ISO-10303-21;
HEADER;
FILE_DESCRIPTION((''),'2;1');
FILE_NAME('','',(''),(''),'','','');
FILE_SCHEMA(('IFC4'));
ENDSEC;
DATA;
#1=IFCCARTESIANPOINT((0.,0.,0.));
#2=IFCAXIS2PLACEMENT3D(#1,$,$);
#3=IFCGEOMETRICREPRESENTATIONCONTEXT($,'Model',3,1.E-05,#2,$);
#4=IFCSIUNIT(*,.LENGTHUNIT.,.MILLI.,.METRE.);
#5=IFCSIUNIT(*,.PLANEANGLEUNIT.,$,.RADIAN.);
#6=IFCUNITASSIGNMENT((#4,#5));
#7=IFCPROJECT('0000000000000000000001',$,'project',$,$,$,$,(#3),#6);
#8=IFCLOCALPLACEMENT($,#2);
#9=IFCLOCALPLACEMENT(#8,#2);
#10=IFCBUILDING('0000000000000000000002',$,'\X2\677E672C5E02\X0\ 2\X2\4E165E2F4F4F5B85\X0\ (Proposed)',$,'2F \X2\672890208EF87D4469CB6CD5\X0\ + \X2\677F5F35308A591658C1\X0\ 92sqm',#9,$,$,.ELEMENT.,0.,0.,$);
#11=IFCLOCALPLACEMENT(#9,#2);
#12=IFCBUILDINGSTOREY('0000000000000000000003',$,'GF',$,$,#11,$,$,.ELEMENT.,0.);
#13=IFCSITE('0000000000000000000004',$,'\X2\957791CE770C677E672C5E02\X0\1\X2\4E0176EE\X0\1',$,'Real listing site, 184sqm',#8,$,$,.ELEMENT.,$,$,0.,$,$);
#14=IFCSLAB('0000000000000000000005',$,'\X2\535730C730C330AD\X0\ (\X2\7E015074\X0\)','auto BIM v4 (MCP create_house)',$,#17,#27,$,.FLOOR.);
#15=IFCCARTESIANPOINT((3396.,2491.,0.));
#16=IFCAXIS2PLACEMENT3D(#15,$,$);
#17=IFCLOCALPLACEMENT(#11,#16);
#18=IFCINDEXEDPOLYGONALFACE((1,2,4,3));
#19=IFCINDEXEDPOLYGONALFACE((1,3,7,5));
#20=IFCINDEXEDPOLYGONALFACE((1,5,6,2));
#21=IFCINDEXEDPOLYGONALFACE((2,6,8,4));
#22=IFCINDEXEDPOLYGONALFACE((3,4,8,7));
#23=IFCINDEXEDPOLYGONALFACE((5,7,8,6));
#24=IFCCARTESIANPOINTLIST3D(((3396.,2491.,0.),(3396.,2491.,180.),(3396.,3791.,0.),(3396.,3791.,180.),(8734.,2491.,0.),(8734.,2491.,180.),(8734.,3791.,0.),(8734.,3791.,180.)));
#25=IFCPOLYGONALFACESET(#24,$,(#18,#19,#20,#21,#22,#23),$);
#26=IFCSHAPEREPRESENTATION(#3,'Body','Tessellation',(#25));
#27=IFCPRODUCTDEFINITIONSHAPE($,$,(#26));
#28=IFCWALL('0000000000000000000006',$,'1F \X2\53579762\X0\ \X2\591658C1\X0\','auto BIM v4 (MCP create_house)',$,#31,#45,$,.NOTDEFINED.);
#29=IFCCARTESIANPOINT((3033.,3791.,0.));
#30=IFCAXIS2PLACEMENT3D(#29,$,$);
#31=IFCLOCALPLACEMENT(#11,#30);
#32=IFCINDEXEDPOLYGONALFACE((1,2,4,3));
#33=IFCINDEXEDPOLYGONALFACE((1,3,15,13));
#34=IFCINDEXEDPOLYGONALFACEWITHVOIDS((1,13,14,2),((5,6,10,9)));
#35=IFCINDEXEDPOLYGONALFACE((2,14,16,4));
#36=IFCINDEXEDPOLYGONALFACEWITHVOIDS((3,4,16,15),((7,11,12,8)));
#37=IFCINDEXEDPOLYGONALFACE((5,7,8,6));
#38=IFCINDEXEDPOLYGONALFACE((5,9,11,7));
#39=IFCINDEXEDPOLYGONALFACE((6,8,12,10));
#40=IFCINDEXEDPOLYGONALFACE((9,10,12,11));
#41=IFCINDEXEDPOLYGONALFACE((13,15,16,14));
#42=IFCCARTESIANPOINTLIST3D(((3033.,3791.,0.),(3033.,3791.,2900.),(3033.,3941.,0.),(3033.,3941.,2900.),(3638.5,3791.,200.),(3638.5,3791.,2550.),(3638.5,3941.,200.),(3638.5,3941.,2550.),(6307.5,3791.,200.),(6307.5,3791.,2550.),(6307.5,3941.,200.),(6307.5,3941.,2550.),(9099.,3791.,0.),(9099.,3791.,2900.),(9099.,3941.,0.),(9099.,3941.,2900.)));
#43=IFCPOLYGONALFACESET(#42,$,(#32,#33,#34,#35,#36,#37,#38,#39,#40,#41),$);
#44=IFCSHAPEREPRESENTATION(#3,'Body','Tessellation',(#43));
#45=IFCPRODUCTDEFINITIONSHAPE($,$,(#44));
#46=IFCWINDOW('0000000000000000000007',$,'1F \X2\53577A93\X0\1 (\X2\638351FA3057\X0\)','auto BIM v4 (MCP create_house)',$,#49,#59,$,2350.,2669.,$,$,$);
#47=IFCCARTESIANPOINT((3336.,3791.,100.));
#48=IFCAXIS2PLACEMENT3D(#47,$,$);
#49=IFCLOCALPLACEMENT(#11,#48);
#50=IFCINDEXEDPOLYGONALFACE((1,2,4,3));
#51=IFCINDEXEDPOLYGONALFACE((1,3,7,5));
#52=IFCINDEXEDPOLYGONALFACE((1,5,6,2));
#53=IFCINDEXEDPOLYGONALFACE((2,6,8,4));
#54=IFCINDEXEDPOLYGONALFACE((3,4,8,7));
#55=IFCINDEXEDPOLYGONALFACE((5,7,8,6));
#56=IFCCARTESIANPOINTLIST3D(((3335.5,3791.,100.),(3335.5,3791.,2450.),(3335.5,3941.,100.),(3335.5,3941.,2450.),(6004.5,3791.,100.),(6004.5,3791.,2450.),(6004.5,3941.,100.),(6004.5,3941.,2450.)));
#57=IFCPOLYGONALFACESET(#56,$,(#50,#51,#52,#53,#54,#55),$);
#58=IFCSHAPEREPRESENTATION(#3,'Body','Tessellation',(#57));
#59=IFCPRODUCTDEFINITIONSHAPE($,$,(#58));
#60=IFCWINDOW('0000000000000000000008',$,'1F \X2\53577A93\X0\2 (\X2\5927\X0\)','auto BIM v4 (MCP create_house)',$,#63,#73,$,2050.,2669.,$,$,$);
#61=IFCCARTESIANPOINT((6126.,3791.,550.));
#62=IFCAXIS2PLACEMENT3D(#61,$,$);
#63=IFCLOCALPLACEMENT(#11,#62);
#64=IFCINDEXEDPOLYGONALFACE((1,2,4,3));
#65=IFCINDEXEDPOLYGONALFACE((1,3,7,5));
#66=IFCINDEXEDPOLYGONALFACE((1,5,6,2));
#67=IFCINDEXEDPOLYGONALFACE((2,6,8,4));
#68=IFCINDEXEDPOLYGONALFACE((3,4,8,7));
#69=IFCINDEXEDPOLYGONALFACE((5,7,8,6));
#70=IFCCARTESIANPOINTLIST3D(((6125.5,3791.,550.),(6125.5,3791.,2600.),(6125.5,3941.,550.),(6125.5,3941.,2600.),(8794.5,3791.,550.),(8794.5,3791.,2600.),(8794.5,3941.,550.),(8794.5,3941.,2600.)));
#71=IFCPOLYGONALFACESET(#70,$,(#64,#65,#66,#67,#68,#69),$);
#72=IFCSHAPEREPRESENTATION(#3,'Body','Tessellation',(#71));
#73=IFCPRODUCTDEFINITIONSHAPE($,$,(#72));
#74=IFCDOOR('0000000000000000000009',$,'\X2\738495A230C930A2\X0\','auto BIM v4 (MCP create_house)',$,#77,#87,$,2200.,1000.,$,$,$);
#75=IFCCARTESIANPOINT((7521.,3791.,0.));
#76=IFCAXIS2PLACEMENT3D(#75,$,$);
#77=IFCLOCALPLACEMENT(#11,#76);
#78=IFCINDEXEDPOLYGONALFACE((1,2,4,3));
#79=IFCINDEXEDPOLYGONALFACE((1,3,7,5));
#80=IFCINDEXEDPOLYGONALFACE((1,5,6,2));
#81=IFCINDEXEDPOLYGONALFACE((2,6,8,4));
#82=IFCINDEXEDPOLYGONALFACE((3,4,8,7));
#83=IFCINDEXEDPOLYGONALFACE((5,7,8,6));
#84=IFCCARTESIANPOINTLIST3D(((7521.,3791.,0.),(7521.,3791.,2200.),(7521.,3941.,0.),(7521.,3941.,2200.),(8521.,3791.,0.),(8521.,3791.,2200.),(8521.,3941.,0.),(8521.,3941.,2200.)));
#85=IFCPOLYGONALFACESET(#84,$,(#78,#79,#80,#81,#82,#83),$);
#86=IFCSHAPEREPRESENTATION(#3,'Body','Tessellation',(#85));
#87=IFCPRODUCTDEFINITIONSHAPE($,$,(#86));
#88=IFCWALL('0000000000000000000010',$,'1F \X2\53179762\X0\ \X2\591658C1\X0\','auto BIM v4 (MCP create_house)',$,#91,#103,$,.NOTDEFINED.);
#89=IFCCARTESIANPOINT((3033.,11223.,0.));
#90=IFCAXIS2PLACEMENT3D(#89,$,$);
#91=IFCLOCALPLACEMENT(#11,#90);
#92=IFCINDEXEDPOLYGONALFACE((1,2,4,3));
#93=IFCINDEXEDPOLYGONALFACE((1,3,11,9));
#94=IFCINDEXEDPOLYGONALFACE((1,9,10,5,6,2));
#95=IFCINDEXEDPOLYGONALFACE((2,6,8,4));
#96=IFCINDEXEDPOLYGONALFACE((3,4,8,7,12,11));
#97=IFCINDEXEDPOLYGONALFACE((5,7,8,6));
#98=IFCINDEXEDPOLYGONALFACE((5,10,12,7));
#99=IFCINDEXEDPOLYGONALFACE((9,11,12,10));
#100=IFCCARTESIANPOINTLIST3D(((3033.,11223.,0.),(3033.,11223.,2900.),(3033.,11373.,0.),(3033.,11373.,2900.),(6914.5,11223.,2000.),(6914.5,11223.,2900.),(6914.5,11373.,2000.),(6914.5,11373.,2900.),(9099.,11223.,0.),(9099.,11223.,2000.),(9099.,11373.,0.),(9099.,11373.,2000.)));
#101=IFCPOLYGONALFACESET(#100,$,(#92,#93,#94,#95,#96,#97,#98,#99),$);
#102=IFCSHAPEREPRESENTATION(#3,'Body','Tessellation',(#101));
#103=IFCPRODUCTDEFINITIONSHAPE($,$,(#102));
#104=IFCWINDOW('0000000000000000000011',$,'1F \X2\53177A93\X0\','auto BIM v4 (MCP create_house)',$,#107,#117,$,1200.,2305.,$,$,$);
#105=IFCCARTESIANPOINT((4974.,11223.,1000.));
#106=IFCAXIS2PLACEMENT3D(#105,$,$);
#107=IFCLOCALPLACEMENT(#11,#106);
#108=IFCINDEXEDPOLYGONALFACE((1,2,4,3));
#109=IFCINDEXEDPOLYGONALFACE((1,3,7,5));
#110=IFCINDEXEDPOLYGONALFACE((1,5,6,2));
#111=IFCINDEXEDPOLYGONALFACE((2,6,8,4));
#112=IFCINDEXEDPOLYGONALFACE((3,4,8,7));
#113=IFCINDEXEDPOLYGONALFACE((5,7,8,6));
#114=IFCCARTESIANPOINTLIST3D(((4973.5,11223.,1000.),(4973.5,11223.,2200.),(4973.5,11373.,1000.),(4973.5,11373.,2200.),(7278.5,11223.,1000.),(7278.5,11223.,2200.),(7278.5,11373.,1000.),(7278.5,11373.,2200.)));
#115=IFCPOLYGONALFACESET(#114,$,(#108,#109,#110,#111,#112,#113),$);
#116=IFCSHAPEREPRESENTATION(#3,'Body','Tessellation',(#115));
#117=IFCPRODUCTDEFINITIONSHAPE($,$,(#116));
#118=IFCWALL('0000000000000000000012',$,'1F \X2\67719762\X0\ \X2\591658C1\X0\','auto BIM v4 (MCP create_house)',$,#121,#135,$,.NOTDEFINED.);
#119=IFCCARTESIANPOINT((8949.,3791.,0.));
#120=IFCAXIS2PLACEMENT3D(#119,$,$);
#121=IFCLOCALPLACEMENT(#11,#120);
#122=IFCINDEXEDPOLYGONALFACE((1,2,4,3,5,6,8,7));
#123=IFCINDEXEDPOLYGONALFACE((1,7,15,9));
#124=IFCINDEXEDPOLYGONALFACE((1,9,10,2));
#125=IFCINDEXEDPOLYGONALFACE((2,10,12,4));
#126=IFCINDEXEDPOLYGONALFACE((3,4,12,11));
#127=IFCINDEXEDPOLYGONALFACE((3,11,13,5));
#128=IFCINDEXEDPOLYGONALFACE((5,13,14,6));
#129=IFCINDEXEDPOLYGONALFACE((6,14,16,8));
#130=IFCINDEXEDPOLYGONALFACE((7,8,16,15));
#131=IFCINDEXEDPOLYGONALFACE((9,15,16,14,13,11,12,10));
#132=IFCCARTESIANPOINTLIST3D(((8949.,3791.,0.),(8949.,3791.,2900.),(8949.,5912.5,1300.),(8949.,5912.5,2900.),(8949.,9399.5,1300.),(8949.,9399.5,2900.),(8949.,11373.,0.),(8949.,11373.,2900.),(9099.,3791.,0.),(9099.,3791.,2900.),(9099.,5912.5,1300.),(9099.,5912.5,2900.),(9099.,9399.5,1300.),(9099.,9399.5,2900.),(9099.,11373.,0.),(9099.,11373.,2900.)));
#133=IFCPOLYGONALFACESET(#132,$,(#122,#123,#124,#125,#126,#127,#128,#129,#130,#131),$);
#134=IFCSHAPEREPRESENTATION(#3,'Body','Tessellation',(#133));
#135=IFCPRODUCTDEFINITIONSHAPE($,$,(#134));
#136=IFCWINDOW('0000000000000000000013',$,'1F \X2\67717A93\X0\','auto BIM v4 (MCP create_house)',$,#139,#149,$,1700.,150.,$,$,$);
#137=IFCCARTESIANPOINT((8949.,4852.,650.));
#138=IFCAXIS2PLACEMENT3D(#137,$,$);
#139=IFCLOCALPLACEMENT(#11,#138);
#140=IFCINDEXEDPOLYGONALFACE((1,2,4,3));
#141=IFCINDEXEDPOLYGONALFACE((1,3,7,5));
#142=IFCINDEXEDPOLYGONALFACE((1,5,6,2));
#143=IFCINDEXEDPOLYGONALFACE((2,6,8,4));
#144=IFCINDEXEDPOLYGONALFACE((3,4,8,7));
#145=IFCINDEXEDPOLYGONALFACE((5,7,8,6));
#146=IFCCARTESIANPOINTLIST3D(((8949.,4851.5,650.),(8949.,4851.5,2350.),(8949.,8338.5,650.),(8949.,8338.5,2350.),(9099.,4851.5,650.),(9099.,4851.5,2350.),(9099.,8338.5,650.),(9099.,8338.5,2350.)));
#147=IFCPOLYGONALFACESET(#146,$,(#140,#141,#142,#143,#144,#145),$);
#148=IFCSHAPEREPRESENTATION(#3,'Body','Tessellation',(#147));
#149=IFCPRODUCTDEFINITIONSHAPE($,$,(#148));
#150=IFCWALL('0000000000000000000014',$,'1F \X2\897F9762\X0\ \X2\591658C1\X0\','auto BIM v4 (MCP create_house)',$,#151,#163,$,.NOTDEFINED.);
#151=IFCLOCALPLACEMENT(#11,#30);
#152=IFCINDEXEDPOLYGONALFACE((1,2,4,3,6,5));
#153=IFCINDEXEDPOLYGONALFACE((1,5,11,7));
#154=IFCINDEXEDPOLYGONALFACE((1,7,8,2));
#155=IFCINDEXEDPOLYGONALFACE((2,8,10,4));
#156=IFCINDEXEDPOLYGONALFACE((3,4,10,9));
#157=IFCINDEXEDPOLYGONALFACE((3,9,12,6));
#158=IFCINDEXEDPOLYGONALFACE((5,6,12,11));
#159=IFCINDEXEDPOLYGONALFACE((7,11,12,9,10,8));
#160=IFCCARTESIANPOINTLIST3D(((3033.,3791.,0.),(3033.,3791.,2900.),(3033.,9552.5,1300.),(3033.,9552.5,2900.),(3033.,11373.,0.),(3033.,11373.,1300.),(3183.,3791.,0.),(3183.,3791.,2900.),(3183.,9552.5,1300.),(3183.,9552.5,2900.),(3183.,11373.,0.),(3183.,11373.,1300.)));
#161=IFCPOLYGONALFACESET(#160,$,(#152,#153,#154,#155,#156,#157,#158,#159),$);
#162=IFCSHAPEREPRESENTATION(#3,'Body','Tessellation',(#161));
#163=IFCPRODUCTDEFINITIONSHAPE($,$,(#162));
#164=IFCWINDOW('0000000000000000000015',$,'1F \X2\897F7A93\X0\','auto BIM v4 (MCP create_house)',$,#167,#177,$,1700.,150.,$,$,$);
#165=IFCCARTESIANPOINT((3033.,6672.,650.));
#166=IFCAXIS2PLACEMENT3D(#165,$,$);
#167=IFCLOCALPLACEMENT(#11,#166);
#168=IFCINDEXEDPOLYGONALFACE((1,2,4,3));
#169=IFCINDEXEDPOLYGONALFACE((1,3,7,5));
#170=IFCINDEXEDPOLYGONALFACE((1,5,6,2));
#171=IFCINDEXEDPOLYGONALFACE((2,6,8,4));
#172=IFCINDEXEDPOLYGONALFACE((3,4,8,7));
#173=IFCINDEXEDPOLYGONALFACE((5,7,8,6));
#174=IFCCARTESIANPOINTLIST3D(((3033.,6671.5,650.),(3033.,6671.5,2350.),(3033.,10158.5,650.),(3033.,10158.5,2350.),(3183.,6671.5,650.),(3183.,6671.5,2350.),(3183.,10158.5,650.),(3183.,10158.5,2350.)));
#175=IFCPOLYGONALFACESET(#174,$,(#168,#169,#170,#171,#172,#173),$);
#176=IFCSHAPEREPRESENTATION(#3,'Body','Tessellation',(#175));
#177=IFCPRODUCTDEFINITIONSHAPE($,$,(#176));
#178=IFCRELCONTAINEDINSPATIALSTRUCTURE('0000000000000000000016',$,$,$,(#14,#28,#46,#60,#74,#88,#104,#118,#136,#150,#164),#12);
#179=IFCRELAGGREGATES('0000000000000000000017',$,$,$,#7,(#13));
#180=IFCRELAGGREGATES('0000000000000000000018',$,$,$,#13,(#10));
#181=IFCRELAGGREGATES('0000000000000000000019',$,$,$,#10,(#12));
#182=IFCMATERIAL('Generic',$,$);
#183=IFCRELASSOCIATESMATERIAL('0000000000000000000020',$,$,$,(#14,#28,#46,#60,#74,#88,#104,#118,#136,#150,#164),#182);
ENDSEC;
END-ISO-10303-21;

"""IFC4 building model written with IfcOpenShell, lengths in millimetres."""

from ifc_helpers import new_model, si_unit, frame, frame_2d, origin, place, context, project, spatial, rectangle, extrude, material, element, fill, save


model = new_model("IFC4")

# Units and contexts
model_context = context("Model", 3, precision=1e-05, world=origin())
ifc_project = project(units=[si_unit("LENGTHUNIT", "METRE", prefix="MILLI"), si_unit("PLANEANGLEUNIT", "RADIAN")], contexts=[model_context])

# Site, building, storey
site_placement = place(None, origin())
site = spatial("IfcSite", under=ifc_project, at=site_placement, Name="長野県松本市1丁目1", ObjectType="Real listing site, 184sqm", CompositionType="ELEMENT", RefElevation=0.0)
building_placement = place(site_placement, origin())
building = spatial("IfcBuilding", under=site, at=building_placement, Name="松本市 2世帯住宅 (Proposed)", ObjectType="2F 木造軸組構法 + 板張り外壁 92sqm", CompositionType="ELEMENT", ElevationOfRefHeight=0.0, ElevationOfTerrain=0.0)
storey_placement = place(building_placement, origin())
storey = spatial("IfcBuildingStorey", under=building, at=storey_placement, Name="GF", CompositionType="ELEMENT", Elevation=0.0)

# Slab
ifc_material = material(Name="Generic")
slab_1_placement = place(storey_placement, frame((3396.0, 2491.0, 0.0)))
element("IfcSlab", 1, at=slab_1_placement, inside=storey, material=ifc_material, Name="南デッキ (縁側)", Description="auto BIM v4 (MCP create_house)", PredefinedType="FLOOR", context=model_context, shape_type="SweptSolid", body=[
    extrude(rectangle(XDim=5338.0, YDim=1300.0, at=frame_2d((2669.0, 650.0))), frame((3396.0, 2491.0, 0.0)), (0.0, 0.0, 1.0), 180.0),
])

# Wall, openings, windows, door
wall_1_placement = place(storey_placement, frame((3033.0, 3791.0, 0.0)))
wall_1 = element("IfcWall", 2, at=wall_1_placement, inside=storey, material=ifc_material, Name="1F 南面 外壁", Description="auto BIM v4 (MCP create_house)", PredefinedType="NOTDEFINED", context=model_context, shape_type="SweptSolid", body=[
    extrude(rectangle(XDim=6066.0, YDim=150.0, at=frame_2d((3033.0, 75.0))), frame((3033.0, 3791.0, 0.0)), (0.0, 0.0, 1.0), 2900.0),
])
opening_1_placement = place(storey_placement, frame((3336.0, 3791.0, 100.0)))
opening_1 = element("IfcOpeningElement", 3, at=opening_1_placement, cuts=wall_1, PredefinedType="NOTDEFINED", context=model_context, shape_type="SweptSolid", body=[
    extrude(rectangle(XDim=2669.0, YDim=150.0, at=frame_2d((1334.0, 75.0))), frame((3336.0, 3791.0, 100.0)), (0.0, 0.0, 1.0), 2350.0),
])
opening_2_placement = place(storey_placement, frame((6126.0, 3791.0, 550.0)))
opening_2 = element("IfcOpeningElement", 4, at=opening_2_placement, cuts=wall_1, PredefinedType="NOTDEFINED", context=model_context, shape_type="SweptSolid", body=[
    extrude(rectangle(XDim=2669.0, YDim=150.0, at=frame_2d((1334.0, 75.0))), frame((6126.0, 3791.0, 550.0)), (0.0, 0.0, 1.0), 2050.0),
])
opening_3_placement = place(storey_placement, frame((7521.0, 3791.0, 0.0)))
opening_3 = element("IfcOpeningElement", 5, at=opening_3_placement, cuts=wall_1, PredefinedType="NOTDEFINED", context=model_context, shape_type="SweptSolid", body=[
    extrude(rectangle(XDim=1000.0, YDim=150.0, at=frame_2d((500.0, 75.0))), frame((7521.0, 3791.0, 0.0)), (0.0, 0.0, 1.0), 2200.0),
])
window_1_placement = place(storey_placement, frame((3336.0, 3791.0, 100.0)))
window_1 = element("IfcWindow", 6, at=window_1_placement, inside=storey, material=ifc_material, Name="1F 南窓1 (掃出し)", Description="auto BIM v4 (MCP create_house)", OverallHeight=2350.0, OverallWidth=2669.0, context=model_context, shape_type="SweptSolid", body=[
    extrude(rectangle(XDim=2669.0, YDim=150.0, at=frame_2d((1334.0, 75.0))), frame((3336.0, 3791.0, 100.0)), (0.0, 0.0, 1.0), 2350.0),
])
fill(opening_1, window_1)
window_2_placement = place(storey_placement, frame((6126.0, 3791.0, 550.0)))
window_2 = element("IfcWindow", 7, at=window_2_placement, inside=storey, material=ifc_material, Name="1F 南窓2 (大)", Description="auto BIM v4 (MCP create_house)", OverallHeight=2050.0, OverallWidth=2669.0, context=model_context, shape_type="SweptSolid", body=[
    extrude(rectangle(XDim=2669.0, YDim=150.0, at=frame_2d((1334.0, 75.0))), frame((6126.0, 3791.0, 550.0)), (0.0, 0.0, 1.0), 2050.0),
])
fill(opening_2, window_2)
door_1_placement = place(storey_placement, frame((7521.0, 3791.0, 0.0)))
door_1 = element("IfcDoor", 8, at=door_1_placement, inside=storey, material=ifc_material, Name="玄関ドア", Description="auto BIM v4 (MCP create_house)", OverallHeight=2200.0, OverallWidth=1000.0, context=model_context, shape_type="SweptSolid", body=[
    extrude(rectangle(XDim=1000.0, YDim=150.0, at=frame_2d((500.0, 75.0))), frame((7521.0, 3791.0, 0.0)), (0.0, 0.0, 1.0), 2200.0),
])
fill(opening_3, door_1)

# Walls, openings, windows
wall_2_placement = place(storey_placement, frame((3033.0, 11223.0, 0.0)))
wall_2 = element("IfcWall", 9, at=wall_2_placement, inside=storey, material=ifc_material, Name="1F 北面 外壁", Description="auto BIM v4 (MCP create_house)", PredefinedType="NOTDEFINED", context=model_context, shape_type="SweptSolid", body=[
    extrude(rectangle(XDim=6066.0, YDim=150.0, at=frame_2d((3033.0, 75.0))), frame((3033.0, 11223.0, 0.0)), (0.0, 0.0, 1.0), 2900.0),
])
opening_4_placement = place(storey_placement, frame((4974.0, 11223.0, 1000.0)))
opening_4 = element("IfcOpeningElement", 10, at=opening_4_placement, cuts=wall_2, PredefinedType="NOTDEFINED", context=model_context, shape_type="SweptSolid", body=[
    extrude(rectangle(XDim=2305.0, YDim=150.0, at=frame_2d((1152.0, 75.0))), frame((4974.0, 11223.0, 1000.0)), (0.0, 0.0, 1.0), 1200.0),
])
window_3_placement = place(storey_placement, frame((4974.0, 11223.0, 1000.0)))
window_3 = element("IfcWindow", 11, at=window_3_placement, inside=storey, material=ifc_material, Name="1F 北窓", Description="auto BIM v4 (MCP create_house)", OverallHeight=1200.0, OverallWidth=2305.0, context=model_context, shape_type="SweptSolid", body=[
    extrude(rectangle(XDim=2305.0, YDim=150.0, at=frame_2d((1152.0, 75.0))), frame((4974.0, 11223.0, 1000.0)), (0.0, 0.0, 1.0), 1200.0),
])
fill(opening_4, window_3)
wall_3_placement = place(storey_placement, frame((8949.0, 3791.0, 0.0)))
wall_3 = element("IfcWall", 12, at=wall_3_placement, inside=storey, material=ifc_material, Name="1F 東面 外壁", Description="auto BIM v4 (MCP create_house)", PredefinedType="NOTDEFINED", context=model_context, shape_type="SweptSolid", body=[
    extrude(rectangle(XDim=150.0, YDim=7582.0, at=frame_2d((75.0, 3791.0))), frame((8949.0, 3791.0, 0.0)), (0.0, 0.0, 1.0), 2900.0),
])
opening_5_placement = place(storey_placement, frame((8949.0, 4852.0, 650.0)))
opening_5 = element("IfcOpeningElement", 13, at=opening_5_placement, cuts=wall_3, PredefinedType="NOTDEFINED", context=model_context, shape_type="SweptSolid", body=[
    extrude(rectangle(XDim=150.0, YDim=3487.0, at=frame_2d((75.0, 1743.0))), frame((8949.0, 4852.0, 650.0)), (0.0, 0.0, 1.0), 1700.0),
])
window_4_placement = place(storey_placement, frame((8949.0, 4852.0, 650.0)))
window_4 = element("IfcWindow", 14, at=window_4_placement, inside=storey, material=ifc_material, Name="1F 東窓", Description="auto BIM v4 (MCP create_house)", OverallHeight=1700.0, OverallWidth=150.0, context=model_context, shape_type="SweptSolid", body=[
    extrude(rectangle(XDim=150.0, YDim=3487.0, at=frame_2d((75.0, 1743.0))), frame((8949.0, 4852.0, 650.0)), (0.0, 0.0, 1.0), 1700.0),
])
fill(opening_5, window_4)
wall_4_placement = place(storey_placement, frame((3033.0, 3791.0, 0.0)))
wall_4 = element("IfcWall", 15, at=wall_4_placement, inside=storey, material=ifc_material, Name="1F 西面 外壁", Description="auto BIM v4 (MCP create_house)", PredefinedType="NOTDEFINED", context=model_context, shape_type="SweptSolid", body=[
    extrude(rectangle(XDim=150.0, YDim=7582.0, at=frame_2d((75.0, 3791.0))), frame((3033.0, 3791.0, 0.0)), (0.0, 0.0, 1.0), 2900.0),
])
opening_6_placement = place(storey_placement, frame((3033.0, 6672.0, 650.0)))
opening_6 = element("IfcOpeningElement", 16, at=opening_6_placement, cuts=wall_4, PredefinedType="NOTDEFINED", context=model_context, shape_type="SweptSolid", body=[
    extrude(rectangle(XDim=150.0, YDim=3487.0, at=frame_2d((75.0, 1743.0))), frame((3033.0, 6672.0, 650.0)), (0.0, 0.0, 1.0), 1700.0),
])
window_5_placement = place(storey_placement, frame((3033.0, 6672.0, 650.0)))
window_5 = element("IfcWindow", 17, at=window_5_placement, inside=storey, material=ifc_material, Name="1F 西窓", Description="auto BIM v4 (MCP create_house)", OverallHeight=1700.0, OverallWidth=150.0, context=model_context, shape_type="SweptSolid", body=[
    extrude(rectangle(XDim=150.0, YDim=3487.0, at=frame_2d((75.0, 1743.0))), frame((3033.0, 6672.0, 650.0)), (0.0, 0.0, 1.0), 1700.0),
])
fill(opening_6, window_5)

save(model, "model.ifc")
